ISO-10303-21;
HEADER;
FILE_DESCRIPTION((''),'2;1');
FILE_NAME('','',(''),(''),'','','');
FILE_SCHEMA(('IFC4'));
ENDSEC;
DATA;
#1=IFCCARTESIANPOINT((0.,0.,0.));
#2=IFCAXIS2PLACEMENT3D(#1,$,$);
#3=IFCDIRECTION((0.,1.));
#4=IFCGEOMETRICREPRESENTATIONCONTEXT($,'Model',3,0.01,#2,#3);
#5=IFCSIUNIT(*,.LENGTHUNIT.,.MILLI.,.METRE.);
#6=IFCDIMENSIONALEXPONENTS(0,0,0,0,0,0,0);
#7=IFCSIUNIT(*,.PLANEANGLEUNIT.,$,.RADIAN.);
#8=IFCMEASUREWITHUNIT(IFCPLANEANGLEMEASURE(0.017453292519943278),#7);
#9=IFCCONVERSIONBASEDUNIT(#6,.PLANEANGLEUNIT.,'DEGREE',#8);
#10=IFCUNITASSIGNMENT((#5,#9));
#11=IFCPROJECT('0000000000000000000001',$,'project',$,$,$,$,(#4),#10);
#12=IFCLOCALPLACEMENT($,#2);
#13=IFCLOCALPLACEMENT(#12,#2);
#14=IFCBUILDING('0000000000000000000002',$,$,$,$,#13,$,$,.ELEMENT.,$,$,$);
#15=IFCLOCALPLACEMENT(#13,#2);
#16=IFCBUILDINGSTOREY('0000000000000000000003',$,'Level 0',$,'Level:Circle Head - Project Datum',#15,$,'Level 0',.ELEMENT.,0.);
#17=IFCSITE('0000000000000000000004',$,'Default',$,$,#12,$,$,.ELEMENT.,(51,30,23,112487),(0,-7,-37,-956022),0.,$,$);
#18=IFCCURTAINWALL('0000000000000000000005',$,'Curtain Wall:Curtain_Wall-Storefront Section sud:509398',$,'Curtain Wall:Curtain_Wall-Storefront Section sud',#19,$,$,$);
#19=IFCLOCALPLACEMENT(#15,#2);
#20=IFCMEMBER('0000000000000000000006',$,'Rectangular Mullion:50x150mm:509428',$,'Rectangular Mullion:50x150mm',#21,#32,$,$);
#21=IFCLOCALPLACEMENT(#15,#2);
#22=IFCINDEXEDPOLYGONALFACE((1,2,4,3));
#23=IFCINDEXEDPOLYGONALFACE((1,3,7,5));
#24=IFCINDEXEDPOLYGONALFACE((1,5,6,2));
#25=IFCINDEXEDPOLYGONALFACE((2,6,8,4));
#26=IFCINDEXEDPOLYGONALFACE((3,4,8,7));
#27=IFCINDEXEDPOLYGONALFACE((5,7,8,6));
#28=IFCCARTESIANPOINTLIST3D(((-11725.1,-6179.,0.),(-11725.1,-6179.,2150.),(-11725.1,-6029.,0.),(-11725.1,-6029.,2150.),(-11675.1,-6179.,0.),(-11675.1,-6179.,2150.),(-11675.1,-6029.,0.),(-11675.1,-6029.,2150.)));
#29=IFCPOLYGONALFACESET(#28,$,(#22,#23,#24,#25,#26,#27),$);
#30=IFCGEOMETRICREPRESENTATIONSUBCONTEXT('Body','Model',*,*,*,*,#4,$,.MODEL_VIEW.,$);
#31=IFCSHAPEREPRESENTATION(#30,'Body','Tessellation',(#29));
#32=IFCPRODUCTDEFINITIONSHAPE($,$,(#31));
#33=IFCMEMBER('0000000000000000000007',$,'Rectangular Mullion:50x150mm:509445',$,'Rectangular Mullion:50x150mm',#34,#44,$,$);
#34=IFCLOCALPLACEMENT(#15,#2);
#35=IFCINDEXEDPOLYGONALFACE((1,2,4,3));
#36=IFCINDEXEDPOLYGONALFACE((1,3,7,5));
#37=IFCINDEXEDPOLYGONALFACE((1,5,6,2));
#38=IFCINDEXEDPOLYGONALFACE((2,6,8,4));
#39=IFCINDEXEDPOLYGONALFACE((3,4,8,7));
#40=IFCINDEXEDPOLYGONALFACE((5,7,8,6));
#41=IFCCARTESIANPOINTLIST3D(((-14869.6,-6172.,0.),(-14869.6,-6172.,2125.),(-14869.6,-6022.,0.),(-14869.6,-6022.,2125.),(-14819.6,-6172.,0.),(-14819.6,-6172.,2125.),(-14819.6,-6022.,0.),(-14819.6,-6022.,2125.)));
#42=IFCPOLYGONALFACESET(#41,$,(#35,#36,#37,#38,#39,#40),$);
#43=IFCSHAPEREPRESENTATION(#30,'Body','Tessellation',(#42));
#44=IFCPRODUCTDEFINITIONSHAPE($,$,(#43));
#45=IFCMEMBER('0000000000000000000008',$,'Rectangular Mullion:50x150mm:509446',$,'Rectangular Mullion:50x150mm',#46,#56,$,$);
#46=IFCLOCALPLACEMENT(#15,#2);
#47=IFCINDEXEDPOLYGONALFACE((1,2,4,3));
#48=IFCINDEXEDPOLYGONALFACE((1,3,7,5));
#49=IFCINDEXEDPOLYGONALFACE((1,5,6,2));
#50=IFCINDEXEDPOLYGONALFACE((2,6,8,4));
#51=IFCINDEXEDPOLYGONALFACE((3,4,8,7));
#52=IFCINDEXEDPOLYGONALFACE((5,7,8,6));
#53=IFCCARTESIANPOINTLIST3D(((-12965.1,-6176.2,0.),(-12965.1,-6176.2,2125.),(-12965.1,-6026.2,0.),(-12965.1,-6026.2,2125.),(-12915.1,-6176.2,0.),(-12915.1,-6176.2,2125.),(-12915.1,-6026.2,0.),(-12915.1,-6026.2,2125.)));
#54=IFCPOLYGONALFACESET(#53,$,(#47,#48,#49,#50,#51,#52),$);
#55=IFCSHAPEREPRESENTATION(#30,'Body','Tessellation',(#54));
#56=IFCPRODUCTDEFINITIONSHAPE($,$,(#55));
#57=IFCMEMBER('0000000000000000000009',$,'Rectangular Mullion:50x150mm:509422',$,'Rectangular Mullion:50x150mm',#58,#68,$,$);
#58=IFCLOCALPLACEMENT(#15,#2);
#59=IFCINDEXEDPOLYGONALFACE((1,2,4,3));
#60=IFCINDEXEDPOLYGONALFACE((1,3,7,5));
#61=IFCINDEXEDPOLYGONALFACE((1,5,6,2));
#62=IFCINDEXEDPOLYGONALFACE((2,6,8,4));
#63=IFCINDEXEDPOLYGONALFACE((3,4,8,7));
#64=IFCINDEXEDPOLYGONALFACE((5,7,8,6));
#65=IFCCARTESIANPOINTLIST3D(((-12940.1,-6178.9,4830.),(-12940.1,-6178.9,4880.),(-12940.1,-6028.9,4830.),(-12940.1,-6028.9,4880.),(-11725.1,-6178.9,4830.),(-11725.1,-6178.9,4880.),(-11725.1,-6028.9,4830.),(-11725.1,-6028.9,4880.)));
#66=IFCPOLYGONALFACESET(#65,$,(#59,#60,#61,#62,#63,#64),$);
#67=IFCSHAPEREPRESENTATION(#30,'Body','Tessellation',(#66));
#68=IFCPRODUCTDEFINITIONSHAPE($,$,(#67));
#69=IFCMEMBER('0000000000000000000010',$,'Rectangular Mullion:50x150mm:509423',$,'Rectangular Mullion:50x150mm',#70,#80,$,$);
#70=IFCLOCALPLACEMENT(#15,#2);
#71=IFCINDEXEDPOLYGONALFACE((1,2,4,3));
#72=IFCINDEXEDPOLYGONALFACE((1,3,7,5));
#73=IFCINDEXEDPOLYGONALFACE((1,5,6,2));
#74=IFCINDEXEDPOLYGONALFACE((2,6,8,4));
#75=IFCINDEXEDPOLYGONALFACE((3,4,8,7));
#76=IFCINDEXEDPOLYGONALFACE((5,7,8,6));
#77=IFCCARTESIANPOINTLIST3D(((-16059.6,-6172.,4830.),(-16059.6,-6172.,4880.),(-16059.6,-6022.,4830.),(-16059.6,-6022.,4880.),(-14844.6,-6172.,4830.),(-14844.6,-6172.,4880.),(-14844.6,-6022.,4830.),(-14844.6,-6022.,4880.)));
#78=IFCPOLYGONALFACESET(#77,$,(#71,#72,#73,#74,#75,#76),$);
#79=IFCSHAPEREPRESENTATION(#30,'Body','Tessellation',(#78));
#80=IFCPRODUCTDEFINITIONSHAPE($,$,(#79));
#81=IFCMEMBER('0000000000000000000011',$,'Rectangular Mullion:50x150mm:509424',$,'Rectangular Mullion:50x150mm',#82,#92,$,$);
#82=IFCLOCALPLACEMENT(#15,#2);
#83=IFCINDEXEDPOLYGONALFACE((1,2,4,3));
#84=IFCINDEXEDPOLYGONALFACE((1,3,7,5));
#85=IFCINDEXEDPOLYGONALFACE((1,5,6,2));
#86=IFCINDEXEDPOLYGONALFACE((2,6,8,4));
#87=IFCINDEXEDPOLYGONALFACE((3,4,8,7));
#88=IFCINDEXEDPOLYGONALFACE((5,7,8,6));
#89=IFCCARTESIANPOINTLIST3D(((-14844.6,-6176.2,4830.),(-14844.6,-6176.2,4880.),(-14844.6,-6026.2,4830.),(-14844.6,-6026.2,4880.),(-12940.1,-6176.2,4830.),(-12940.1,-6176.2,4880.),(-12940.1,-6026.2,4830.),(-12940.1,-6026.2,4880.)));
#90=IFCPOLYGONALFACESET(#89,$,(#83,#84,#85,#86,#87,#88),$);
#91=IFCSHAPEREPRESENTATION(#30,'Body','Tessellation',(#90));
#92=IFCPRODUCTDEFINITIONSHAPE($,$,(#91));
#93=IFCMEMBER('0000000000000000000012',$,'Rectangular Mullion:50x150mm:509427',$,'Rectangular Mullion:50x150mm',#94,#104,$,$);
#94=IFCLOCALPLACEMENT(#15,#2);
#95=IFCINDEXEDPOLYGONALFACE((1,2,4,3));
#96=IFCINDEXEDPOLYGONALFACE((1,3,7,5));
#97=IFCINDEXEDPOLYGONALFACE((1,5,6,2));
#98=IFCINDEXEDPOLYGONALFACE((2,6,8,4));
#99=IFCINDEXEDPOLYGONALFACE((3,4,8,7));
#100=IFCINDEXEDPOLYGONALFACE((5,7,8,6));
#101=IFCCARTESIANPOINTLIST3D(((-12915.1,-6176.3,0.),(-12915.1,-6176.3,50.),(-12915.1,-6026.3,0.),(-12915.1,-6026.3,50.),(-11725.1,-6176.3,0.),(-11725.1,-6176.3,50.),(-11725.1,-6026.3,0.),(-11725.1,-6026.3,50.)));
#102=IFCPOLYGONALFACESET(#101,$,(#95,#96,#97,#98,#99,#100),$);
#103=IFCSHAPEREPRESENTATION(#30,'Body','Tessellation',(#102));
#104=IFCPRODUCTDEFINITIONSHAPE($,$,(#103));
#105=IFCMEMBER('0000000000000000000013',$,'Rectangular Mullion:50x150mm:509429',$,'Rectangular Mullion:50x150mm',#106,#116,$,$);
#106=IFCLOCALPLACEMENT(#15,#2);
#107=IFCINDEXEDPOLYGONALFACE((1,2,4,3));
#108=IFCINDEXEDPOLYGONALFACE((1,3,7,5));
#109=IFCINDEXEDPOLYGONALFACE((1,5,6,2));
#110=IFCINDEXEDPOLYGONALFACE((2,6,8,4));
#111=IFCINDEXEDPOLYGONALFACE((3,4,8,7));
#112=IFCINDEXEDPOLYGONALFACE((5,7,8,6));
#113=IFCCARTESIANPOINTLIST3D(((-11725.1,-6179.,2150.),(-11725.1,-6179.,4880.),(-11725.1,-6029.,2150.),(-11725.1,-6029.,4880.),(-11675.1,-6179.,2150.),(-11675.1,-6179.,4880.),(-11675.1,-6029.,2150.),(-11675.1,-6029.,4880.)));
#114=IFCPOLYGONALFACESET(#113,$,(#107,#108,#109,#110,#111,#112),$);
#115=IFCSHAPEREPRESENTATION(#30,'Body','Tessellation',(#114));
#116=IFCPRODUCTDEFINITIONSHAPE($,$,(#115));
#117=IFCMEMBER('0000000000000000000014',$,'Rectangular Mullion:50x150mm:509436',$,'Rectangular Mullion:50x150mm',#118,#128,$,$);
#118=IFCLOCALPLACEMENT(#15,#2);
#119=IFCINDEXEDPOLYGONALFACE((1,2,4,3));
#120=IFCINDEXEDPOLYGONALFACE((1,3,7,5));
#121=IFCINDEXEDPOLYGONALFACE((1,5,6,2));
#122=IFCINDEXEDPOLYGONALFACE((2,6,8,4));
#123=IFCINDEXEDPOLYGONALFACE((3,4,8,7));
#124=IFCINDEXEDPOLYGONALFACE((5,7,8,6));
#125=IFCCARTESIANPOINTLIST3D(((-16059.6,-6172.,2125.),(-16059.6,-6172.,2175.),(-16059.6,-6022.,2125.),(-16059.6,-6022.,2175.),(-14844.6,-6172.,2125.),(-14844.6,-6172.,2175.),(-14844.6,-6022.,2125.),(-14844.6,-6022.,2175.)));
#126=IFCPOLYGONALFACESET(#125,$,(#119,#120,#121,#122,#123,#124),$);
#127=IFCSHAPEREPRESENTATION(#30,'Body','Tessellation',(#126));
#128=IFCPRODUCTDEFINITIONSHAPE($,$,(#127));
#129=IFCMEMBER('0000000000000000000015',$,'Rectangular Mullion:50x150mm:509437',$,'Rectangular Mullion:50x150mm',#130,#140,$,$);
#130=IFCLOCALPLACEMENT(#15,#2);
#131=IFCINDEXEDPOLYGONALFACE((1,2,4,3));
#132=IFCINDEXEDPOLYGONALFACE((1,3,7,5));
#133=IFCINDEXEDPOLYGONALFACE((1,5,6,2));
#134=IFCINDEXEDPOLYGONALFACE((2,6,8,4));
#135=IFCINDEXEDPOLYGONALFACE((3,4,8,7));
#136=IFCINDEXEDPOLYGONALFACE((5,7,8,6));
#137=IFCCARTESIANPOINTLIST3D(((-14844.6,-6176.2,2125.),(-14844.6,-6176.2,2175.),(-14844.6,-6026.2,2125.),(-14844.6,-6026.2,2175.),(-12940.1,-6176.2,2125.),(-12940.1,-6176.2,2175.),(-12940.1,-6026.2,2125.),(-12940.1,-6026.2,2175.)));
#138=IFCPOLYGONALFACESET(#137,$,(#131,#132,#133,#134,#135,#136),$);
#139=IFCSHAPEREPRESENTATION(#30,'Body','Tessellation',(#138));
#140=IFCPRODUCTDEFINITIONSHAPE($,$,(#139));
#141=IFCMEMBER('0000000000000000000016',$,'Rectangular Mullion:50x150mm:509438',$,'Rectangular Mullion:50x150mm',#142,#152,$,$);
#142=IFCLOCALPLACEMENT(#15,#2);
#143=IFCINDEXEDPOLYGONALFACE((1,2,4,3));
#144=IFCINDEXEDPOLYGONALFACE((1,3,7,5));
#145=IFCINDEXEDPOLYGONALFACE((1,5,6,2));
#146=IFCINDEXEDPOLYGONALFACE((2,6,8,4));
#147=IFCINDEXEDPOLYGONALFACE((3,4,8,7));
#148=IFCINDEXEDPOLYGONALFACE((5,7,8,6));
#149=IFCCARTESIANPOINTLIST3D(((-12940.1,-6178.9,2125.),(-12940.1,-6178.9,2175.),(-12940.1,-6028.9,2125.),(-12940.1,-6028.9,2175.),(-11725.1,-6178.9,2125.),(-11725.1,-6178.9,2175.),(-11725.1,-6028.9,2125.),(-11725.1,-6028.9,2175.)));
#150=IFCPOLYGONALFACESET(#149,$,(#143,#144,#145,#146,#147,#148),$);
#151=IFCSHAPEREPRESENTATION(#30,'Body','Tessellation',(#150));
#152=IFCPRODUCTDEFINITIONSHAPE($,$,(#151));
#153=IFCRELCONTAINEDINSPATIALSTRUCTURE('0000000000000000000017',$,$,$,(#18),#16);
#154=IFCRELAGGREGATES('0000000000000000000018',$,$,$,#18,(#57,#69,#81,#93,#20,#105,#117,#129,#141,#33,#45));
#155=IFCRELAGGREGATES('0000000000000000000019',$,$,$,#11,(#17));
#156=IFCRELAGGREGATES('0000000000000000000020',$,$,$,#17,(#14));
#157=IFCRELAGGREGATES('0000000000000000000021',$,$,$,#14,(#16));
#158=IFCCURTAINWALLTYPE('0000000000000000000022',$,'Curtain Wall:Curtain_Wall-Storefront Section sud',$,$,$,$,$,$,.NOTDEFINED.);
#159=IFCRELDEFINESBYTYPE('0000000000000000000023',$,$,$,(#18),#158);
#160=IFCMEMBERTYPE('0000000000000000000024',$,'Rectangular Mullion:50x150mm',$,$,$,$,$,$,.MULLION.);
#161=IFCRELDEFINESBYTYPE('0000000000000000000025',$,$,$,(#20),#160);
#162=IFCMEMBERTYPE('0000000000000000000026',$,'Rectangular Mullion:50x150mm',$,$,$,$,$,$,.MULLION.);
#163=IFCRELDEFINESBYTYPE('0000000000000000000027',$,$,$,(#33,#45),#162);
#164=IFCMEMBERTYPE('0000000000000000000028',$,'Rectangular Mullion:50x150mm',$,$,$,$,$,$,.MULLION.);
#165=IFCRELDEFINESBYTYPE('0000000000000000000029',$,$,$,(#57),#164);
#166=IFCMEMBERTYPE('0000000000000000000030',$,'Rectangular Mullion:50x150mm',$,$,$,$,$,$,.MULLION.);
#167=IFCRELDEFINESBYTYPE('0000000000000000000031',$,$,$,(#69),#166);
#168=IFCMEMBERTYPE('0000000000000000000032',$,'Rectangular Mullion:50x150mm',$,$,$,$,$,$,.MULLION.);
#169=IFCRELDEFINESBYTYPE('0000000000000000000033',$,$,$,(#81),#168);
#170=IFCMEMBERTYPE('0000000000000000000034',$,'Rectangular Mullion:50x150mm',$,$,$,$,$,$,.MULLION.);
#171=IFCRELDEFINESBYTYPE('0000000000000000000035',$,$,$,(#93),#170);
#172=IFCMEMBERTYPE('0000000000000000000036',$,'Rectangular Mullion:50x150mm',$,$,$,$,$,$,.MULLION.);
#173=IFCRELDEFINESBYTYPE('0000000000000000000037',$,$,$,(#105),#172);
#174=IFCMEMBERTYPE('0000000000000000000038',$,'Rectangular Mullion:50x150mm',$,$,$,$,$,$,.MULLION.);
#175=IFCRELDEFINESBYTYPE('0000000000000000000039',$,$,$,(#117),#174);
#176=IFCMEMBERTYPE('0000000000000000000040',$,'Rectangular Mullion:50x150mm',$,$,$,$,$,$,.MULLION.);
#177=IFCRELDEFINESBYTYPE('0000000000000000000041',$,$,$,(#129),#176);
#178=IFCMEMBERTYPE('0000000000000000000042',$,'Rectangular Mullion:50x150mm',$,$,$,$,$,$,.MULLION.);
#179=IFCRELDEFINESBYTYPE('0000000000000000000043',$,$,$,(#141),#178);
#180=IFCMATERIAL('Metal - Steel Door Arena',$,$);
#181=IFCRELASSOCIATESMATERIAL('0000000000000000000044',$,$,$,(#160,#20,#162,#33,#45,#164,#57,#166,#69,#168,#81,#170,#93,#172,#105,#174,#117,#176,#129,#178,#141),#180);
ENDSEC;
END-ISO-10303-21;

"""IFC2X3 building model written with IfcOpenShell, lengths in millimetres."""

from ifc_helpers import new_model, entity, si_unit, converted_unit, direction, frame, origin, origin_2d_with_axis, place, context, subcontext, project, spatial, rectangle, extrude, source, transform, mapped, material, type_object, type_shapes, element, aggregate, save


model = new_model("IFC2X3")

# Units and contexts
model_context = context("Model", 3, precision=0.01, world=origin(), true_north=direction((0.0, 1.0)))
body_context = subcontext(model_context, "Body", "Model", "MODEL_VIEW")
ifc_project = project(units=[si_unit("LENGTHUNIT", "METRE", prefix="MILLI"), converted_unit("PLANEANGLEUNIT", "DEGREE", entity("IfcPlaneAngleMeasure", 0.017453292519943278), si_unit("PLANEANGLEUNIT", "RADIAN"), dimensions=[0, 0, 0, 0, 0, 0, 0])], contexts=[model_context])

# Site, building, storey
site_placement = place(None, origin())
site = spatial("IfcSite", under=ifc_project, at=site_placement, Name="Default", CompositionType="ELEMENT", RefLatitude=(51, 30, 23, 112487), RefLongitude=(0, -7, -37, -956022), RefElevation=0.0)
building_placement = place(site_placement, origin())
building = spatial("IfcBuilding", under=site, at=building_placement, CompositionType="ELEMENT")
storey_placement = place(building_placement, origin())
storey = spatial("IfcBuildingStorey", under=building, at=storey_placement, Name="Level 0", ObjectType="Level:Circle Head - Project Datum", LongName="Level 0", CompositionType="ELEMENT", Elevation=0.0)

# Curtain wall, members
curtain_wall_type = type_object("IfcCurtainWallType", Name="Curtain Wall:Curtain_Wall-Storefront Section sud", PredefinedType="NOTDEFINED")
curtain_wall_placement = place(storey_placement, origin())
curtain_wall = element("IfcCurtainWall", 1, at=curtain_wall_placement, inside=storey, type_object=curtain_wall_type, Name="Curtain Wall:Curtain_Wall-Storefront Section sud:509398", ObjectType="Curtain Wall:Curtain_Wall-Storefront Section sud")
ifc_material_1 = material(Name="Metal - Steel Door Arena")
member_type_1 = type_object("IfcMemberType", Name="Rectangular Mullion:50x150mm", PredefinedType="MULLION", material=ifc_material_1)
shared_shape_1 = source(origin(), body_context, "Body", "SweptSolid", [
    extrude(rectangle(XDim=50.0, YDim=150.0, at=origin_2d_with_axis()), frame((-25.0, 0.0, -2150.0), z_axis=(0.0, 0.0, 1.0), x_axis=(-1.0, 0.0, 0.0)), (0.0, 0.0, 1.0), 2150.0),
])
type_shapes(member_type_1, [shared_shape_1])
member_1_placement = place(curtain_wall_placement, frame((-11675.1, -6104.0, 0.0), z_axis=(0.0, 0.0, -1.0), x_axis=(1.0, 0.0, 0.0)))
member_1 = element("IfcMember", 2, at=member_1_placement, type_object=member_type_1, material=ifc_material_1, Name="Rectangular Mullion:50x150mm:509428", ObjectType="Rectangular Mullion:50x150mm", context=body_context, shape_type="MappedRepresentation", body=[
    mapped(shared_shape_1, transform((0.0, 0.0, 0.0), scale=1.0)),
])
member_type_2 = type_object("IfcMemberType", Name="Rectangular Mullion:50x150mm", PredefinedType="MULLION", material=ifc_material_1)
shared_shape_2 = source(origin(), body_context, "Body", "SweptSolid", [
    extrude(rectangle(XDim=50.0, YDim=150.0, at=origin_2d_with_axis()), frame((0.0, 0.0, -2125.0), z_axis=(0.0, 0.0, 1.0), x_axis=(-1.0, 0.0, 0.0)), (0.0, 0.0, 1.0), 2125.0),
])
type_shapes(member_type_2, [shared_shape_2])
member_2_placement = place(curtain_wall_placement, frame((-14844.6, -6097.0, 0.0), z_axis=(0.0, 0.0, -1.0), x_axis=(1.0, 0.0, 0.0)))
member_2 = element("IfcMember", 3, at=member_2_placement, type_object=member_type_2, material=ifc_material_1, Name="Rectangular Mullion:50x150mm:509445", ObjectType="Rectangular Mullion:50x150mm", context=body_context, shape_type="MappedRepresentation", body=[
    mapped(shared_shape_2, transform((0.0, 0.0, 0.0), scale=1.0)),
])
member_3_placement = place(curtain_wall_placement, frame((-12940.1, -6101.2, 0.0), z_axis=(0.0, 0.0, -1.0), x_axis=(1.0, 0.0, 0.0)))
member_3 = element("IfcMember", 4, at=member_3_placement, type_object=member_type_2, material=ifc_material_1, Name="Rectangular Mullion:50x150mm:509446", ObjectType="Rectangular Mullion:50x150mm", context=body_context, shape_type="MappedRepresentation", body=[
    mapped(shared_shape_2, transform((0.0, 0.0, 0.0), scale=1.0)),
])
member_type_3 = type_object("IfcMemberType", Name="Rectangular Mullion:50x150mm", PredefinedType="MULLION", material=ifc_material_1)
shared_shape_3 = source(origin(), body_context, "Body", "SweptSolid", [
    extrude(rectangle(XDim=50.0, YDim=150.0, at=origin_2d_with_axis()), frame((-25.0, 0.0, -1215.0), z_axis=(0.0, 0.0, 1.0), x_axis=(-1.0, 0.0, 0.0)), (0.0, 0.0, 1.0), 1215.0),
])
type_shapes(member_type_3, [shared_shape_3])
member_4_placement = place(curtain_wall_placement, frame((-11725.1, -6103.9, 4880.0), z_axis=(1.0, 0.0, 0.0), x_axis=(0.0, 0.0, 1.0)))
member_4 = element("IfcMember", 5, at=member_4_placement, type_object=member_type_3, material=ifc_material_1, Name="Rectangular Mullion:50x150mm:509422", ObjectType="Rectangular Mullion:50x150mm", context=body_context, shape_type="MappedRepresentation", body=[
    mapped(shared_shape_3, transform((0.0, 0.0, 0.0), scale=1.0)),
])
member_type_4 = type_object("IfcMemberType", Name="Rectangular Mullion:50x150mm", PredefinedType="MULLION", material=ifc_material_1)
shared_shape_4 = source(origin(), body_context, "Body", "SweptSolid", [
    extrude(rectangle(XDim=50.0, YDim=150.0, at=origin_2d_with_axis()), frame((-25.0, 0.0, -1215.0), z_axis=(0.0, 0.0, 1.0), x_axis=(-1.0, 0.0, 0.0)), (0.0, 0.0, 1.0), 1215.0),
])
type_shapes(member_type_4, [shared_shape_4])
member_5_placement = place(curtain_wall_placement, frame((-14844.6, -6097.0, 4880.0), z_axis=(1.0, 0.0, 0.0), x_axis=(0.0, 0.0, 1.0)))
member_5 = element("IfcMember", 6, at=member_5_placement, type_object=member_type_4, material=ifc_material_1, Name="Rectangular Mullion:50x150mm:509423", ObjectType="Rectangular Mullion:50x150mm", context=body_context, shape_type="MappedRepresentation", body=[
    mapped(shared_shape_4, transform((0.0, 0.0, 0.0), scale=1.0)),
])
member_type_5 = type_object("IfcMemberType", Name="Rectangular Mullion:50x150mm", PredefinedType="MULLION", material=ifc_material_1)
shared_shape_5 = source(origin(), body_context, "Body", "SweptSolid", [
    extrude(rectangle(XDim=50.0, YDim=150.0, at=origin_2d_with_axis()), frame((-25.0, 0.0, -1904.5), z_axis=(0.0, 0.0, 1.0), x_axis=(-1.0, 0.0, 0.0)), (0.0, 0.0, 1.0), 1904.5),
])
type_shapes(member_type_5, [shared_shape_5])
member_6_placement = place(curtain_wall_placement, frame((-12940.1, -6101.2, 4880.0), z_axis=(1.0, 0.0, 0.0), x_axis=(0.0, 0.0, 1.0)))
member_6 = element("IfcMember", 7, at=member_6_placement, type_object=member_type_5, material=ifc_material_1, Name="Rectangular Mullion:50x150mm:509424", ObjectType="Rectangular Mullion:50x150mm", context=body_context, shape_type="MappedRepresentation", body=[
    mapped(shared_shape_5, transform((0.0, 0.0, 0.0), scale=1.0)),
])
member_type_6 = type_object("IfcMemberType", Name="Rectangular Mullion:50x150mm", PredefinedType="MULLION", material=ifc_material_1)
shared_shape_6 = source(origin(), body_context, "Body", "SweptSolid", [
    extrude(rectangle(XDim=50.0, YDim=150.0, at=origin_2d_with_axis()), frame((-25.0, 0.0, -1190.0), z_axis=(0.0, 0.0, 1.0), x_axis=(-1.0, 0.0, 0.0)), (0.0, 0.0, 1.0), 1190.0),
])
type_shapes(member_type_6, [shared_shape_6])
member_7_placement = place(curtain_wall_placement, frame((-12915.1, -6101.3, 0.0), z_axis=(-1.0, 0.0, 0.0), x_axis=(0.0, 0.0, -1.0)))
member_7 = element("IfcMember", 8, at=member_7_placement, type_object=member_type_6, material=ifc_material_1, Name="Rectangular Mullion:50x150mm:509427", ObjectType="Rectangular Mullion:50x150mm", context=body_context, shape_type="MappedRepresentation", body=[
    mapped(shared_shape_6, transform((0.0, 0.0, 0.0), scale=1.0)),
])
member_type_7 = type_object("IfcMemberType", Name="Rectangular Mullion:50x150mm", PredefinedType="MULLION", material=ifc_material_1)
shared_shape_7 = source(origin(), body_context, "Body", "SweptSolid", [
    extrude(rectangle(XDim=50.0, YDim=150.0, at=origin_2d_with_axis()), frame((-25.0, 0.0, -2730.0), z_axis=(0.0, 0.0, 1.0), x_axis=(-1.0, 0.0, 0.0)), (0.0, 0.0, 1.0), 2730.0),
])
type_shapes(member_type_7, [shared_shape_7])
member_8_placement = place(curtain_wall_placement, frame((-11675.1, -6104.0, 2150.0), z_axis=(0.0, 0.0, -1.0), x_axis=(1.0, 0.0, 0.0)))
member_8 = element("IfcMember", 9, at=member_8_placement, type_object=member_type_7, material=ifc_material_1, Name="Rectangular Mullion:50x150mm:509429", ObjectType="Rectangular Mullion:50x150mm", context=body_context, shape_type="MappedRepresentation", body=[
    mapped(shared_shape_7, transform((0.0, 0.0, 0.0), scale=1.0)),
])
member_type_8 = type_object("IfcMemberType", Name="Rectangular Mullion:50x150mm", PredefinedType="MULLION", material=ifc_material_1)
shared_shape_8 = source(origin(), body_context, "Body", "SweptSolid", [
    extrude(rectangle(XDim=50.0, YDim=150.0, at=origin_2d_with_axis()), frame((0.0, 0.0, -1215.0), z_axis=(0.0, 0.0, 1.0), x_axis=(-1.0, 0.0, 0.0)), (0.0, 0.0, 1.0), 1215.0),
])
type_shapes(member_type_8, [shared_shape_8])
member_9_placement = place(curtain_wall_placement, frame((-14844.6, -6097.0, 2150.0), z_axis=(1.0, 0.0, 0.0), x_axis=(0.0, 0.0, 1.0)))
member_9 = element("IfcMember", 10, at=member_9_placement, type_object=member_type_8, material=ifc_material_1, Name="Rectangular Mullion:50x150mm:509436", ObjectType="Rectangular Mullion:50x150mm", context=body_context, shape_type="MappedRepresentation", body=[
    mapped(shared_shape_8, transform((0.0, 0.0, 0.0), scale=1.0)),
])
member_type_9 = type_object("IfcMemberType", Name="Rectangular Mullion:50x150mm", PredefinedType="MULLION", material=ifc_material_1)
shared_shape_9 = source(origin(), body_context, "Body", "SweptSolid", [
    extrude(rectangle(XDim=50.0, YDim=150.0, at=origin_2d_with_axis()), frame((0.0, 0.0, -1904.5), z_axis=(0.0, 0.0, 1.0), x_axis=(-1.0, 0.0, 0.0)), (0.0, 0.0, 1.0), 1904.5),
])
type_shapes(member_type_9, [shared_shape_9])
member_10_placement = place(curtain_wall_placement, frame((-12940.1, -6101.2, 2150.0), z_axis=(1.0, 0.0, 0.0), x_axis=(0.0, 0.0, 1.0)))
member_10 = element("IfcMember", 11, at=member_10_placement, type_object=member_type_9, material=ifc_material_1, Name="Rectangular Mullion:50x150mm:509437", ObjectType="Rectangular Mullion:50x150mm", context=body_context, shape_type="MappedRepresentation", body=[
    mapped(shared_shape_9, transform((0.0, 0.0, 0.0), scale=1.0)),
])
member_type_10 = type_object("IfcMemberType", Name="Rectangular Mullion:50x150mm", PredefinedType="MULLION", material=ifc_material_1)
shared_shape_10 = source(origin(), body_context, "Body", "SweptSolid", [
    extrude(rectangle(XDim=50.0, YDim=150.0, at=origin_2d_with_axis()), frame((0.0, 0.0, -1215.0), z_axis=(0.0, 0.0, 1.0), x_axis=(-1.0, 0.0, 0.0)), (0.0, 0.0, 1.0), 1215.0),
])
type_shapes(member_type_10, [shared_shape_10])
member_11_placement = place(curtain_wall_placement, frame((-11725.1, -6103.9, 2150.0), z_axis=(1.0, 0.0, 0.0), x_axis=(0.0, 0.0, 1.0)))
member_11 = element("IfcMember", 12, at=member_11_placement, type_object=member_type_10, material=ifc_material_1, Name="Rectangular Mullion:50x150mm:509438", ObjectType="Rectangular Mullion:50x150mm", context=body_context, shape_type="MappedRepresentation", body=[
    mapped(shared_shape_10, transform((0.0, 0.0, 0.0), scale=1.0)),
])
aggregate(curtain_wall, [member_4, member_5, member_6, member_7, member_1, member_8, member_9, member_10, member_11, member_2, member_3])

save(model, "model.ifc")
